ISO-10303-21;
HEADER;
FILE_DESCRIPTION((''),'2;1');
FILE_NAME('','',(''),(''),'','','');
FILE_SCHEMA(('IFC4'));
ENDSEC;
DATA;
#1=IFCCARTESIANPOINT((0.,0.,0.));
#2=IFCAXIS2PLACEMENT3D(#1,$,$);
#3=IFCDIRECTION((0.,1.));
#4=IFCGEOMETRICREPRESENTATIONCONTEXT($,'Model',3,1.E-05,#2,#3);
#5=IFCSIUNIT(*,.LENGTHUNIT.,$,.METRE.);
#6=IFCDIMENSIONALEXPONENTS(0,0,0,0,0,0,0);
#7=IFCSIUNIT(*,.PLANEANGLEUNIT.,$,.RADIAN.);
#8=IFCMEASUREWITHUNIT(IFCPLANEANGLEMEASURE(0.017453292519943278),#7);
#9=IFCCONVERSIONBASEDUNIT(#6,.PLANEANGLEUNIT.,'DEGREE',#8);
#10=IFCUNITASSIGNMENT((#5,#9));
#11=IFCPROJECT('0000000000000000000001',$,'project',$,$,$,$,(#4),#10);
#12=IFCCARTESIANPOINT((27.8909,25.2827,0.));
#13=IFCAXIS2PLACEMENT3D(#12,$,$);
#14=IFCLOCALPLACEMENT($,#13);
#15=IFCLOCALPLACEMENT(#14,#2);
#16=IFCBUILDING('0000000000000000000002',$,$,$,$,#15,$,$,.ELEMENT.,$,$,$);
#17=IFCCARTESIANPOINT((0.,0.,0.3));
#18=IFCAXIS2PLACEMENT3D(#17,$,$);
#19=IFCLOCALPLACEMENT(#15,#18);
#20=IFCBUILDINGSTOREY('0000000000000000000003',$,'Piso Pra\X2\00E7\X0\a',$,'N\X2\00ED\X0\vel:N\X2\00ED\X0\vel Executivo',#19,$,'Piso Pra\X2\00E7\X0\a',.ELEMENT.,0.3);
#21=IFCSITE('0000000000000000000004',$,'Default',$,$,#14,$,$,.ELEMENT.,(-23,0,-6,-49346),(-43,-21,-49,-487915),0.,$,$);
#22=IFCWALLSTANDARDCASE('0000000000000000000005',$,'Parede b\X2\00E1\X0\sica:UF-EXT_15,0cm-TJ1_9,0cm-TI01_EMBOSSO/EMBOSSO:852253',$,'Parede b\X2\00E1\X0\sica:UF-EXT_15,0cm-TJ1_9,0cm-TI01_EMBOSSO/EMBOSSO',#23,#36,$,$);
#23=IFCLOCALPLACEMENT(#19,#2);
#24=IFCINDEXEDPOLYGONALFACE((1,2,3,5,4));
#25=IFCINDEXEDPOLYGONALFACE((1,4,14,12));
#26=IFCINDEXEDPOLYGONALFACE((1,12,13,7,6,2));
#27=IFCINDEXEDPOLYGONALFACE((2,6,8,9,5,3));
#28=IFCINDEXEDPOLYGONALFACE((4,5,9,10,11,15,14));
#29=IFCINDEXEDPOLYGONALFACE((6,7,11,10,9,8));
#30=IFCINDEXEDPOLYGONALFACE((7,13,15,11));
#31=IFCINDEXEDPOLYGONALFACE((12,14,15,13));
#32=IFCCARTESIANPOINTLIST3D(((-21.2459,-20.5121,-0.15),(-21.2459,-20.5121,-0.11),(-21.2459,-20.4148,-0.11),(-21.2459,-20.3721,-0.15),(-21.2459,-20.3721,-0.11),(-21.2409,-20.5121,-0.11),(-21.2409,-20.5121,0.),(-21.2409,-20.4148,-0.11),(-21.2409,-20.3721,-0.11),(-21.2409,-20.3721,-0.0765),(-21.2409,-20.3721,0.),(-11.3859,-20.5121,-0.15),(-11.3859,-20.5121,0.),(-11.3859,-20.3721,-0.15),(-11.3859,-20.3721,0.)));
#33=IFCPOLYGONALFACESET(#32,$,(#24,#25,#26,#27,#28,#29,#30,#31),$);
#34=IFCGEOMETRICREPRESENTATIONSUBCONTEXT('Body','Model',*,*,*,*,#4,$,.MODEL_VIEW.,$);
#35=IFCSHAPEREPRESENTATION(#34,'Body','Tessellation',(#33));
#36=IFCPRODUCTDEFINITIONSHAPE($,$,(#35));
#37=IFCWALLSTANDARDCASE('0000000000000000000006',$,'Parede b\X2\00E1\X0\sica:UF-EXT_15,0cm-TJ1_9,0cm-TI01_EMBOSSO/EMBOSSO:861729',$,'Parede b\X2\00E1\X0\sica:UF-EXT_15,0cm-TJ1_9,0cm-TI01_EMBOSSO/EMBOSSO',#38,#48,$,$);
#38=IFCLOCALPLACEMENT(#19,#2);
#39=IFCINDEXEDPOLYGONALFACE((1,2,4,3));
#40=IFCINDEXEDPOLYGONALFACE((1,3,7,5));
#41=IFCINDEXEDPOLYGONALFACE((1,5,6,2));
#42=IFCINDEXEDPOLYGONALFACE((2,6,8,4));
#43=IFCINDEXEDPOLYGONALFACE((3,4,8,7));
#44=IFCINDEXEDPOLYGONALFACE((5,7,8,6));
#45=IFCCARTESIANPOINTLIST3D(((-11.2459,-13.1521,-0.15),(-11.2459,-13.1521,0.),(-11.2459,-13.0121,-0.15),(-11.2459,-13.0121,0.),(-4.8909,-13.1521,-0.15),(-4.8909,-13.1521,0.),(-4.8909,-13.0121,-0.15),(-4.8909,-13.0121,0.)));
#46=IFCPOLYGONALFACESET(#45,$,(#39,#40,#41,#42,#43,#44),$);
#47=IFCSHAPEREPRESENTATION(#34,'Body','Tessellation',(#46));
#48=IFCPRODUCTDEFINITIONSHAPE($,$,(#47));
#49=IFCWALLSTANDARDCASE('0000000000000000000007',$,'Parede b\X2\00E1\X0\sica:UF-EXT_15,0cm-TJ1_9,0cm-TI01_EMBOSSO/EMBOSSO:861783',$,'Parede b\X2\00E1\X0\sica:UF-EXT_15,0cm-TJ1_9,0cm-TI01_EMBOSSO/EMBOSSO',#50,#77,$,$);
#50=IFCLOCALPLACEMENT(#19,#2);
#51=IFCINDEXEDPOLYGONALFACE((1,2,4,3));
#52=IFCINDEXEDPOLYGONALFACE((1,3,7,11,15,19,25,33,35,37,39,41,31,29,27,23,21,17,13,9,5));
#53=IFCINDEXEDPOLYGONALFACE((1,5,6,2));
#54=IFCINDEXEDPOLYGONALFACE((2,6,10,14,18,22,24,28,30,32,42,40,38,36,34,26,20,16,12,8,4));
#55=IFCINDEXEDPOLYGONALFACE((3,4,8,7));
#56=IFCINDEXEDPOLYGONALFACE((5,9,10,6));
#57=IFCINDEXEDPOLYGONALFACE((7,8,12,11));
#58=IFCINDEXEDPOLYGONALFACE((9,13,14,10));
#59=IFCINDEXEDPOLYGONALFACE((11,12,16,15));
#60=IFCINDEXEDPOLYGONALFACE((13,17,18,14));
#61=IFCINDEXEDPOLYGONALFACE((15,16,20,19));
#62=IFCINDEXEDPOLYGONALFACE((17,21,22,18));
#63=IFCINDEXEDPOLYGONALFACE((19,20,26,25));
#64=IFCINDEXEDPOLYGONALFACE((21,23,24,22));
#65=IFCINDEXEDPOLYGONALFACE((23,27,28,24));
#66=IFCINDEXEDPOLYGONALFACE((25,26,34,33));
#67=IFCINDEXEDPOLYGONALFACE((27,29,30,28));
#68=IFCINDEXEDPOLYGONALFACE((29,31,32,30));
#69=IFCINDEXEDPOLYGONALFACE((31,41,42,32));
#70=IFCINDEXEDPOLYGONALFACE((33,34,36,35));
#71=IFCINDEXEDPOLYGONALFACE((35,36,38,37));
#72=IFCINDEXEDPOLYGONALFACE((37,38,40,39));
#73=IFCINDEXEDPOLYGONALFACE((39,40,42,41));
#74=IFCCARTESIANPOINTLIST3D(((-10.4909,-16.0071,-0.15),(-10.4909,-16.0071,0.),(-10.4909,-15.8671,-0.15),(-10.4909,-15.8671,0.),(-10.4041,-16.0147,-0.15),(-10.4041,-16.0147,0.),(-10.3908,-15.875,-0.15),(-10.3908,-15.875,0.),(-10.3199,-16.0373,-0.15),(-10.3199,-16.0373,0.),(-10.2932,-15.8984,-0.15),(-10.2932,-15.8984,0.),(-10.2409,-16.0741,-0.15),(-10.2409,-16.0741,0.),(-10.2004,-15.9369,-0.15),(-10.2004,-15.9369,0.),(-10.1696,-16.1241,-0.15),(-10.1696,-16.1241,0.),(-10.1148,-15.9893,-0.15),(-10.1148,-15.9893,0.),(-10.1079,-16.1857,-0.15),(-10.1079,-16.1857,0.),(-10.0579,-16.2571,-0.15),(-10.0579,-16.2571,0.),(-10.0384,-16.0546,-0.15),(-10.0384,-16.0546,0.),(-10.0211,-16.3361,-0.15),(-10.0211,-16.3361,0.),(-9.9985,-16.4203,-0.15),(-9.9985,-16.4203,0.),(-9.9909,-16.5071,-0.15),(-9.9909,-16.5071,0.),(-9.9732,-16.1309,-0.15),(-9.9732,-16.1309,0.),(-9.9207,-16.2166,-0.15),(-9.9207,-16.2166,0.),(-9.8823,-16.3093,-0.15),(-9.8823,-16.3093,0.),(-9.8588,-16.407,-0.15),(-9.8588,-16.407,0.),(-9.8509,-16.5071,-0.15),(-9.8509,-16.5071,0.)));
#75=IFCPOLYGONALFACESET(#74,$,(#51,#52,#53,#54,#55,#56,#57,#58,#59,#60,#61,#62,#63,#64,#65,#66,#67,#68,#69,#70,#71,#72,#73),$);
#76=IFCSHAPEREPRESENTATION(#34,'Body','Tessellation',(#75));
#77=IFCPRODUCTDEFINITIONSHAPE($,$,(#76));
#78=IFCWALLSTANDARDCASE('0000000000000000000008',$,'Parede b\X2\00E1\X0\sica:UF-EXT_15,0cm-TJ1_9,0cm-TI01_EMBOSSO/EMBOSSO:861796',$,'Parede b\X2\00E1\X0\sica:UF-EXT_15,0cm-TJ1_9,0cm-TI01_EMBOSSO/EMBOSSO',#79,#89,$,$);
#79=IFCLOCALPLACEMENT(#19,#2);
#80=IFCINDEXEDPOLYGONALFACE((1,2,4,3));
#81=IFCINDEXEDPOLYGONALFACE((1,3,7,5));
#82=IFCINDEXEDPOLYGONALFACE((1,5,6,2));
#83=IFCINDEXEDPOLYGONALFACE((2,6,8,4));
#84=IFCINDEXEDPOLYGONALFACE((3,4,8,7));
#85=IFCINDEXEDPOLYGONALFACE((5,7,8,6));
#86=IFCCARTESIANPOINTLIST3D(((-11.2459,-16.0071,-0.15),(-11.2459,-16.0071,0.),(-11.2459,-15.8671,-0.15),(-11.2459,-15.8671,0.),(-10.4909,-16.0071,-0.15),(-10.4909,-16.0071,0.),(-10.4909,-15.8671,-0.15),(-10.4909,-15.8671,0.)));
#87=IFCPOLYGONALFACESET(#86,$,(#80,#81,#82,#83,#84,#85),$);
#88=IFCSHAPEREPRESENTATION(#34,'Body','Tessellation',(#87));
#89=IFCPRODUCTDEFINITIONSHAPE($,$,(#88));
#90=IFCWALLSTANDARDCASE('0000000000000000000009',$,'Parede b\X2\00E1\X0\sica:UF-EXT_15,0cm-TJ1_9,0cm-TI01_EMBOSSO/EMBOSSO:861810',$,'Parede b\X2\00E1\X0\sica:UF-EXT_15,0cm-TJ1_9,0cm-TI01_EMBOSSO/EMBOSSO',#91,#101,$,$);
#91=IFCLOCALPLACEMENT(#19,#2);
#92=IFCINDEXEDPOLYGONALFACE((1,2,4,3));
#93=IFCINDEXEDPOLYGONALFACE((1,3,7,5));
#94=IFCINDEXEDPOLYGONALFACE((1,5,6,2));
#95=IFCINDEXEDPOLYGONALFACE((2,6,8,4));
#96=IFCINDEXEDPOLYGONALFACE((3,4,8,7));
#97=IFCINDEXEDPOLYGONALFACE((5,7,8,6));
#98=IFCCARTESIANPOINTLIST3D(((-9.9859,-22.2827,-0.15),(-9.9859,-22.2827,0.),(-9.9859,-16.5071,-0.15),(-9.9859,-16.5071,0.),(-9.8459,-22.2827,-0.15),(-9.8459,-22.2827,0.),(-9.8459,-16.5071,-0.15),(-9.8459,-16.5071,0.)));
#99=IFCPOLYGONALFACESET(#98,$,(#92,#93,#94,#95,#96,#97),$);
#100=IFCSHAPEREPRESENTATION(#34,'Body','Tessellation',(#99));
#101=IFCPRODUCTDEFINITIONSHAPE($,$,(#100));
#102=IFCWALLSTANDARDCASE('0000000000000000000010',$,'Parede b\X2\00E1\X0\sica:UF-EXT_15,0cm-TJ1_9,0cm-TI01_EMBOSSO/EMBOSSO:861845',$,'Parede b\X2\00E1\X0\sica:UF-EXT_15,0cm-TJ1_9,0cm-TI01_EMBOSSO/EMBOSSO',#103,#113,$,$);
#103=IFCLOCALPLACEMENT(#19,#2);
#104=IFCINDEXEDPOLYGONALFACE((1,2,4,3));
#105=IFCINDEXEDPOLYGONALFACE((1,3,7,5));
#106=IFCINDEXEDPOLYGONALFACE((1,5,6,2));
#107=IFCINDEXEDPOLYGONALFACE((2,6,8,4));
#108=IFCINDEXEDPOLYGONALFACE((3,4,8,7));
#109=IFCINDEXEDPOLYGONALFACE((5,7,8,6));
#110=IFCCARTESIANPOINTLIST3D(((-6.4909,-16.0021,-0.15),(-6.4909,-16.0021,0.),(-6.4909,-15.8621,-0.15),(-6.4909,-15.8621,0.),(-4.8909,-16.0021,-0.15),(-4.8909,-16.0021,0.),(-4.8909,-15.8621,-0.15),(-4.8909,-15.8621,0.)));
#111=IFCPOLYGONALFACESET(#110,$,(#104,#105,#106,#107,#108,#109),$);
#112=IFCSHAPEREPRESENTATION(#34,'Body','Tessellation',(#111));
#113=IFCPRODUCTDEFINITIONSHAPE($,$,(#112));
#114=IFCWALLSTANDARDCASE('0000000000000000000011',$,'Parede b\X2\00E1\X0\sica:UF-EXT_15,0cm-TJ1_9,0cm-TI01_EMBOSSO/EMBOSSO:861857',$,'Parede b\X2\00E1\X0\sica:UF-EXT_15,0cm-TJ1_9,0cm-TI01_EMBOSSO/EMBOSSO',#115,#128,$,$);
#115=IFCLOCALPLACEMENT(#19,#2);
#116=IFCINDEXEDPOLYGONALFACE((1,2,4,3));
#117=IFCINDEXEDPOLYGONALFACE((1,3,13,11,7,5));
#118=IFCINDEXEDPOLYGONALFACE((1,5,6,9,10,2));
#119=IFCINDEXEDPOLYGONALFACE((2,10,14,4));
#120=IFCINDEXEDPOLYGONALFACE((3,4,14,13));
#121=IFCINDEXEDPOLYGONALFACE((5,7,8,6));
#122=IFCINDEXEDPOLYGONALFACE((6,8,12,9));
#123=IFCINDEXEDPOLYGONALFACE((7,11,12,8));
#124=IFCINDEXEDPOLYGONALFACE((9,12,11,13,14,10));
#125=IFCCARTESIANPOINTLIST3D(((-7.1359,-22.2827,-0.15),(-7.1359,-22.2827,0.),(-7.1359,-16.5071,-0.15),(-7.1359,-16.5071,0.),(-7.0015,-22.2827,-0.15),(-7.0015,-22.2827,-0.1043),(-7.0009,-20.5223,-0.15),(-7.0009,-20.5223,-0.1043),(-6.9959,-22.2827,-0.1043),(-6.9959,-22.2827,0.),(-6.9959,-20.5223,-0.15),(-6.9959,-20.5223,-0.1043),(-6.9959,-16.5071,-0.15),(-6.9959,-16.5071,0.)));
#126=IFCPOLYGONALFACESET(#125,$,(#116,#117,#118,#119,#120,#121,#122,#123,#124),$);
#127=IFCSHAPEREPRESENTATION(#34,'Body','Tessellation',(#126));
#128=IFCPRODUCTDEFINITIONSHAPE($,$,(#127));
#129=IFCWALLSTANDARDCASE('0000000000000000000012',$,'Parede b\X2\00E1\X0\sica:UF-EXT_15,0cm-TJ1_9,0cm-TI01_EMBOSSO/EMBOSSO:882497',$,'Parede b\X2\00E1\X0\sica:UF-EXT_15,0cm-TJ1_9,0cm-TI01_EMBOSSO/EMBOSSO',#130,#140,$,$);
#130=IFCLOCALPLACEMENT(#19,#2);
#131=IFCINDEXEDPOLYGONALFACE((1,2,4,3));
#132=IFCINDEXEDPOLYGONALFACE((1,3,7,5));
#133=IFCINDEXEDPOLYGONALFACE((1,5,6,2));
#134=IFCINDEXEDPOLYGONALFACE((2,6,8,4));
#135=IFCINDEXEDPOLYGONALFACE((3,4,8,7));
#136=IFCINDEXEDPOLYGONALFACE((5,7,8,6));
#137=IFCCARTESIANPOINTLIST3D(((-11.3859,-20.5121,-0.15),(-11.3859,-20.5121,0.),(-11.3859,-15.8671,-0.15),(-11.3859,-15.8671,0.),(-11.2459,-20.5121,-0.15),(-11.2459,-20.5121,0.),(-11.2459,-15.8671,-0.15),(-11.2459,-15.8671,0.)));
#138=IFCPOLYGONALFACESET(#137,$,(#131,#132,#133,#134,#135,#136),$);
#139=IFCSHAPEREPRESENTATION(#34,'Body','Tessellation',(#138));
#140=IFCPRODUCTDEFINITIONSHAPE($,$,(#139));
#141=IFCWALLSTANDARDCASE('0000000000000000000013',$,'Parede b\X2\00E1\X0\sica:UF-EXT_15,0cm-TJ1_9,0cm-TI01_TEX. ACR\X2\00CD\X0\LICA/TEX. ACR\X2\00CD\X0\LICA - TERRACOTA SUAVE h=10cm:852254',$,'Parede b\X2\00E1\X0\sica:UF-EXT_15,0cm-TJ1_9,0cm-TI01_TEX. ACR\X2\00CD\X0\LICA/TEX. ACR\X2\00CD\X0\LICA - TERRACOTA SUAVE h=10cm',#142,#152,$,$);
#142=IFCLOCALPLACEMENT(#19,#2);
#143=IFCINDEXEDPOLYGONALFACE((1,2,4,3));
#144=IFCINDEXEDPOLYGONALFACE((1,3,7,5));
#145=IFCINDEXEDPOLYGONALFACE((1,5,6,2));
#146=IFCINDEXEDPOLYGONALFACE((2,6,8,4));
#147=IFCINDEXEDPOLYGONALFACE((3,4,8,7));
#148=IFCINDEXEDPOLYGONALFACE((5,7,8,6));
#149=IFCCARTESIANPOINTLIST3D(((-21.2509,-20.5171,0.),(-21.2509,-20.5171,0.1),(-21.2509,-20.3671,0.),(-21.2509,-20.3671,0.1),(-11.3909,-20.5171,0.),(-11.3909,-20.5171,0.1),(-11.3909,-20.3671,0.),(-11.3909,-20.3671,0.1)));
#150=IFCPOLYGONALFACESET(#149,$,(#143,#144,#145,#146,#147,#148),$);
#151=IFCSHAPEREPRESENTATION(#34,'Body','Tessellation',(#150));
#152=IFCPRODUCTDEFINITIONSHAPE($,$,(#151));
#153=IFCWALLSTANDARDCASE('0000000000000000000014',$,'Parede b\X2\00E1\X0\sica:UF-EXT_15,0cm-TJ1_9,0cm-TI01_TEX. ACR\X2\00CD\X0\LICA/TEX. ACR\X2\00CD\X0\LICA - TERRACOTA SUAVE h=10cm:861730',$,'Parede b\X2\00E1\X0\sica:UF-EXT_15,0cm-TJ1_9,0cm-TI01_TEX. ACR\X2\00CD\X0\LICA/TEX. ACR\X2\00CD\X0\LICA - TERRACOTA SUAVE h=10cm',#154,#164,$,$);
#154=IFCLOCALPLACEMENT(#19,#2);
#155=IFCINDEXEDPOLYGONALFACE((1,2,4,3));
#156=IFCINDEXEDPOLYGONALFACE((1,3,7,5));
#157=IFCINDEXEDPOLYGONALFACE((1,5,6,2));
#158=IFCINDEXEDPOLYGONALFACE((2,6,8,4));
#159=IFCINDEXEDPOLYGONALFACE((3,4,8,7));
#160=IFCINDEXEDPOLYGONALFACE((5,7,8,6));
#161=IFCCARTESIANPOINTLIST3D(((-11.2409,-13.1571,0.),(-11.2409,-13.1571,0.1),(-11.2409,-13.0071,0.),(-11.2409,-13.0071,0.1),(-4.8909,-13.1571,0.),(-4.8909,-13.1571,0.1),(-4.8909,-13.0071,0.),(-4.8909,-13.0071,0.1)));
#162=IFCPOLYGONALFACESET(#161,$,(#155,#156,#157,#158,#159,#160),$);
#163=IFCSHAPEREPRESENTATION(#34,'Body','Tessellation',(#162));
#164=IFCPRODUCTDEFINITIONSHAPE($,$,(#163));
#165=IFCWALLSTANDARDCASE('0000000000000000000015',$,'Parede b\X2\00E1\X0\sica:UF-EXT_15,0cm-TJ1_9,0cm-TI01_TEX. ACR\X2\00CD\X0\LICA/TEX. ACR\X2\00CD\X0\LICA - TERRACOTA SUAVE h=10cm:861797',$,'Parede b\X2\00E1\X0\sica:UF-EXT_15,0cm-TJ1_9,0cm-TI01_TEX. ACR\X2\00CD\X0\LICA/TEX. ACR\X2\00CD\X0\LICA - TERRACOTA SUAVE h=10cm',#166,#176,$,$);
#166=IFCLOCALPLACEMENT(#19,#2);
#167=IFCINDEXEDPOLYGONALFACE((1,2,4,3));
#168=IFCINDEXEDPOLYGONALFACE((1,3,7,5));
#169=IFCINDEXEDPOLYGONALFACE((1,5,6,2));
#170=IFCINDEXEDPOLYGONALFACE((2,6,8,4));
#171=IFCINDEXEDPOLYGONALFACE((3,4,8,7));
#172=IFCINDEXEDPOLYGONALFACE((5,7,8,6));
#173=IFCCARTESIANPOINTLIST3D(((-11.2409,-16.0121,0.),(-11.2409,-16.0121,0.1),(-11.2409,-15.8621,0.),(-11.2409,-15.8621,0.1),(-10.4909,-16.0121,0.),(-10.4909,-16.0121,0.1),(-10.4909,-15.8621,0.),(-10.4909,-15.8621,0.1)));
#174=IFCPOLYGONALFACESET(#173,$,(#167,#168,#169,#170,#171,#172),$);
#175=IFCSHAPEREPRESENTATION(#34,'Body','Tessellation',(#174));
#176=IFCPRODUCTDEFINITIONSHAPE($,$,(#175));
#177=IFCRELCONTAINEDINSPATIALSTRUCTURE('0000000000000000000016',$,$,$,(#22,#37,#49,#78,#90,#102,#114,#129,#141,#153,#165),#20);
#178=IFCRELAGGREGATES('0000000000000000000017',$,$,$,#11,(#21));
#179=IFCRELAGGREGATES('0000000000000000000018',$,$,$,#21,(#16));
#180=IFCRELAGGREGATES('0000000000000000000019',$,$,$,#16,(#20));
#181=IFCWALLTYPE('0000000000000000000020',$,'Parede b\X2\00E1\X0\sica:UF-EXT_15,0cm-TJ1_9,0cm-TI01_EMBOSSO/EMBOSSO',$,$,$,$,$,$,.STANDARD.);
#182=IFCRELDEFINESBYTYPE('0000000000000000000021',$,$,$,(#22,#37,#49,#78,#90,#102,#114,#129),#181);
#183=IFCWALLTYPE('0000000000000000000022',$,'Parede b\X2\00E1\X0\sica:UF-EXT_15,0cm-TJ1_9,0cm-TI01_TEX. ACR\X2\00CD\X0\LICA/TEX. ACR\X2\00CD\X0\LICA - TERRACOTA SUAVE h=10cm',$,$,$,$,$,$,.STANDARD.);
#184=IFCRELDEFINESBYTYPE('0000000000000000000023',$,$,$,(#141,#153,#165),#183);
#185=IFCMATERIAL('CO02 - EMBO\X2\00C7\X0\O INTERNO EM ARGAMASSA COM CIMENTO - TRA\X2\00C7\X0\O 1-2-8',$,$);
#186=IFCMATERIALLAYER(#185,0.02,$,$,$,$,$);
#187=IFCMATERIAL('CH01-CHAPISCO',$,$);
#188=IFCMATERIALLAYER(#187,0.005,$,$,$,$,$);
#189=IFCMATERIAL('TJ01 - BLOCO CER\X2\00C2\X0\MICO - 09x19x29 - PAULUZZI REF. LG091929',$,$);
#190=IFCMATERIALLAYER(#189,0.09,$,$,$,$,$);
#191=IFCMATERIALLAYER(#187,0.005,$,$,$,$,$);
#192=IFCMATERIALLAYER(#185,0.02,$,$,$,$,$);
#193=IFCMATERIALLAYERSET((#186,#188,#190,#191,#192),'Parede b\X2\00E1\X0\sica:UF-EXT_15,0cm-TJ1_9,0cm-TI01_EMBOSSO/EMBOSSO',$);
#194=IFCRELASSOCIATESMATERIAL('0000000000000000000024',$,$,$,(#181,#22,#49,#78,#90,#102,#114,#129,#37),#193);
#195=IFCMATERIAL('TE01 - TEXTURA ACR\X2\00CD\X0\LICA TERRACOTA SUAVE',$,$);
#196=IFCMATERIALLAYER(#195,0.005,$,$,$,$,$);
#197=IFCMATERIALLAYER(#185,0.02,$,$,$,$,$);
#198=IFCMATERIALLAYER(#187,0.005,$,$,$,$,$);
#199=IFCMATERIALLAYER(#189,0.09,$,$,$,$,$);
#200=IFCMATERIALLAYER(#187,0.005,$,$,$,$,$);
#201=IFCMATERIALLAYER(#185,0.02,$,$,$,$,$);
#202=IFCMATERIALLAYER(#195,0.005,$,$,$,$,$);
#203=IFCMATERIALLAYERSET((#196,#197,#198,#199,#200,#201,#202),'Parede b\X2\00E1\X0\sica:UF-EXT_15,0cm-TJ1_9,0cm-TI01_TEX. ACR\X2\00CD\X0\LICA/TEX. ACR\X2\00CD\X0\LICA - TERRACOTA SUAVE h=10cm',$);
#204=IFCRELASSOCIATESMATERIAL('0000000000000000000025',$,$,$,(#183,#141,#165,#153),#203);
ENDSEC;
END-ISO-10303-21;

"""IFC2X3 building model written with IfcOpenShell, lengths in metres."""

from ifc_helpers import new_model, entity, si_unit, converted_unit, direction, frame, frame_2d, origin, place, context, subcontext, project, spatial, polyline, circle_curve, parameter, trimmed, segment, composite_curve, rectangle, outline, extrude, clip, bounded_halfspace, material, layer, layer_set, layer_usage, type_object, element, save


model = new_model("IFC2X3")

# Units and contexts
model_context = context("Model", 3, precision=1e-05, world=origin(), true_north=direction((0.0, 1.0)))
body_context = subcontext(model_context, "Body", "Model", "MODEL_VIEW")
ifc_project = project(units=[si_unit("LENGTHUNIT", "METRE"), converted_unit("PLANEANGLEUNIT", "DEGREE", entity("IfcPlaneAngleMeasure", 0.017453292519943278), si_unit("PLANEANGLEUNIT", "RADIAN"), dimensions=[0, 0, 0, 0, 0, 0, 0])], contexts=[model_context])

# Site, building, storey
site_placement = place(None, frame((27.8909, 25.2827, 0.0)))
site = spatial("IfcSite", under=ifc_project, at=site_placement, Name="Default", CompositionType="ELEMENT", RefLatitude=(-23, 0, -6, -49346), RefLongitude=(-43, -21, -49, -487915), RefElevation=0.0)
building_placement = place(site_placement, origin())
building = spatial("IfcBuilding", under=site, at=building_placement, CompositionType="ELEMENT")
storey_placement = place(building_placement, frame((0.0, 0.0, 0.3)))
storey = spatial("IfcBuildingStorey", under=building, at=storey_placement, Name="Piso Praça", ObjectType="Nível:Nível Executivo", LongName="Piso Praça", CompositionType="ELEMENT", Elevation=0.3)

# Walls
ifc_material_1 = material(Name="CO02 - EMBOÇO INTERNO EM ARGAMASSA COM CIMENTO - TRAÇO 1-2-8")
ifc_layer_1 = layer(ifc_material_1, 0.02)
ifc_material_2 = material(Name="CH01-CHAPISCO")
ifc_layer_2 = layer(ifc_material_2, 0.005)
ifc_material_3 = material(Name="TJ01 - BLOCO CERÂMICO - 09x19x29 - PAULUZZI REF. LG091929")
ifc_layer_3 = layer(ifc_material_3, 0.09)
ifc_layer_4 = layer(ifc_material_2, 0.005)
ifc_layer_5 = layer(ifc_material_1, 0.02)
ifc_layer_set_1 = layer_set([ifc_layer_1, ifc_layer_2, ifc_layer_3, ifc_layer_4, ifc_layer_5], Name="Parede básica:UF-EXT_15,0cm-TJ1_9,0cm-TI01_EMBOSSO/EMBOSSO")
ifc_layer_usage_1 = layer_usage(ifc_layer_set_1, "AXIS2", "NEGATIVE", 0.07)
wall_type_1 = type_object("IfcWallType", Name="Parede básica:UF-EXT_15,0cm-TJ1_9,0cm-TI01_EMBOSSO/EMBOSSO", PredefinedType="STANDARD", material=ifc_layer_set_1)
wall_1_placement = place(storey_placement, frame((-11.3859, -20.4421, -0.15), z_axis=(0.0, 0.0, 1.0), x_axis=(-1.0, 0.0, 0.0)))
element("IfcWallStandardCase", 1, at=wall_1_placement, inside=storey, type_object=wall_type_1, material=ifc_layer_usage_1, Name="Parede básica:UF-EXT_15,0cm-TJ1_9,0cm-TI01_EMBOSSO/EMBOSSO:852253", ObjectType="Parede básica:UF-EXT_15,0cm-TJ1_9,0cm-TI01_EMBOSSO/EMBOSSO", context=body_context, shape_type="Clipping", body=[
    clip(clip(extrude(rectangle(XDim=9.86, YDim=0.14, at=frame_2d((4.93, 0.0), x_axis=(-1.0, 0.0))), origin(), (0.0, 0.0, 1.0), 0.15), bounded_halfspace(frame((9.855, 0.07, 0.04), z_axis=(0.0, 0.0, -1.0), x_axis=(-1.0, 0.0, 0.0)), True, frame((9.855, 0.07, 0.04), z_axis=(0.0, 0.0, -1.0), x_axis=(-1.0, 0.0, 0.0)), polyline([(0.0, 0.0), (-0.005, 0.0), (-0.005, -0.14), (0.0, -0.14), (0.0, 0.0)]))), bounded_halfspace(frame((9.855, -0.07, 0.04), z_axis=(-1.0, 0.0, 0.0), x_axis=(0.0, 0.0, 1.0)), True, frame((9.855, -0.07, 0.04), z_axis=(-1.0, 0.0, 0.0), x_axis=(0.0, 0.0, 1.0)), polyline([(0.0, 0.0), (0.0335, 0.0), (0.0335, 0.0427), (0.0, 0.0427), (0.0, 0.0)]))),
])
ifc_layer_usage_2 = layer_usage(ifc_layer_set_1, "AXIS2", "POSITIVE", -0.07)
wall_2_placement = place(storey_placement, frame((-11.2459, -13.0821, -0.15)))
element("IfcWallStandardCase", 2, at=wall_2_placement, inside=storey, type_object=wall_type_1, material=ifc_layer_usage_2, Name="Parede básica:UF-EXT_15,0cm-TJ1_9,0cm-TI01_EMBOSSO/EMBOSSO:861729", ObjectType="Parede básica:UF-EXT_15,0cm-TJ1_9,0cm-TI01_EMBOSSO/EMBOSSO", context=body_context, shape_type="SweptSolid", body=[
    extrude(rectangle(XDim=6.355, YDim=0.14, at=frame_2d((3.1775, 0.0), x_axis=(-1.0, 0.0))), origin(), (0.0, 0.0, 1.0), 0.15),
])
wall_3_placement = place(storey_placement, frame((-9.9209, -16.5071, -0.15)))
element("IfcWallStandardCase", 3, at=wall_3_placement, inside=storey, type_object=wall_type_1, material=ifc_layer_usage_1, Name="Parede básica:UF-EXT_15,0cm-TJ1_9,0cm-TI01_EMBOSSO/EMBOSSO:861783", ObjectType="Parede básica:UF-EXT_15,0cm-TJ1_9,0cm-TI01_EMBOSSO/EMBOSSO", context=body_context, shape_type="SweptSolid", body=[
    extrude(outline(composite_curve([segment(trimmed(circle_curve(frame_2d((-0.57, 0.0), x_axis=(1.0, 0.0)), 0.5), [parameter(0.0)], [parameter(90.0)], True, "PARAMETER"), False, "CONTINUOUS"), segment(polyline([(-0.07, 0.0), (0.07, 0.0)]), True, "CONTINUOUS"), segment(trimmed(circle_curve(frame_2d((-0.57, 0.0), x_axis=(1.0, 0.0)), 0.64), [parameter(0.0)], [parameter(90.0)], True, "PARAMETER"), True, "CONTINUOUS"), segment(polyline([(-0.57, 0.64), (-0.57, 0.5)]), True, "CONTINUOUS")], self_intersect=False)), origin(), (0.0, 0.0, 1.0), 0.15),
])
wall_4_placement = place(storey_placement, frame((-10.4909, -15.9371, -0.15), z_axis=(0.0, 0.0, 1.0), x_axis=(-1.0, 0.0, 0.0)))
element("IfcWallStandardCase", 4, at=wall_4_placement, inside=storey, type_object=wall_type_1, material=ifc_layer_usage_1, Name="Parede básica:UF-EXT_15,0cm-TJ1_9,0cm-TI01_EMBOSSO/EMBOSSO:861796", ObjectType="Parede básica:UF-EXT_15,0cm-TJ1_9,0cm-TI01_EMBOSSO/EMBOSSO", context=body_context, shape_type="SweptSolid", body=[
    extrude(rectangle(XDim=0.755, YDim=0.14, at=frame_2d((0.3775, 0.0), x_axis=(-1.0, 0.0))), origin(), (0.0, 0.0, 1.0), 0.15),
])
wall_5_placement = place(storey_placement, frame((-9.9159, -22.2827, -0.15), z_axis=(0.0, 0.0, 1.0), x_axis=(0.0, 1.0, 0.0)))
element("IfcWallStandardCase", 5, at=wall_5_placement, inside=storey, type_object=wall_type_1, material=ifc_layer_usage_1, Name="Parede básica:UF-EXT_15,0cm-TJ1_9,0cm-TI01_EMBOSSO/EMBOSSO:861810", ObjectType="Parede básica:UF-EXT_15,0cm-TJ1_9,0cm-TI01_EMBOSSO/EMBOSSO", context=body_context, shape_type="SweptSolid", body=[
    extrude(rectangle(XDim=5.7756, YDim=0.14, at=frame_2d((2.8878, 0.0), x_axis=(-1.0, 0.0))), origin(), (0.0, 0.0, 1.0), 0.15),
])
wall_6_placement = place(storey_placement, frame((-6.4909, -15.9321, -0.15)))
element("IfcWallStandardCase", 6, at=wall_6_placement, inside=storey, type_object=wall_type_1, material=ifc_layer_usage_1, Name="Parede básica:UF-EXT_15,0cm-TJ1_9,0cm-TI01_EMBOSSO/EMBOSSO:861845", ObjectType="Parede básica:UF-EXT_15,0cm-TJ1_9,0cm-TI01_EMBOSSO/EMBOSSO", context=body_context, shape_type="SweptSolid", body=[
    extrude(rectangle(XDim=1.6, YDim=0.14, at=frame_2d((0.8, 0.0), x_axis=(-1.0, 0.0))), origin(), (0.0, 0.0, 1.0), 0.15),
])
wall_7_placement = place(storey_placement, frame((-7.0659, -22.2827, -0.15), z_axis=(0.0, 0.0, 1.0), x_axis=(0.0, 1.0, 0.0)))
element("IfcWallStandardCase", 7, at=wall_7_placement, inside=storey, type_object=wall_type_1, material=ifc_layer_usage_1, Name="Parede básica:UF-EXT_15,0cm-TJ1_9,0cm-TI01_EMBOSSO/EMBOSSO:861857", ObjectType="Parede básica:UF-EXT_15,0cm-TJ1_9,0cm-TI01_EMBOSSO/EMBOSSO", context=body_context, shape_type="Clipping", body=[
    clip(extrude(rectangle(XDim=5.7756, YDim=0.14, at=frame_2d((2.8878, 0.0), x_axis=(-1.0, 0.0))), origin(), (0.0, 0.0, 1.0), 0.15), bounded_halfspace(frame((0.0, -0.0645, 0.0), z_axis=(0.00031, 1.0, 0.0), x_axis=(0.0, 0.0, 1.0)), True, frame((0.0, -0.0645, 0.0), z_axis=(0.00031, 1.0, 0.0), x_axis=(0.0, 0.0, 1.0)), polyline([(0.0, 0.0), (0.0457, 0.0), (0.0457, 1.7604), (0.0, 1.7604), (0.0, 0.0)]))),
])
wall_8_placement = place(storey_placement, frame((-11.3159, -15.8671, -0.15), z_axis=(0.0, 0.0, 1.0), x_axis=(0.0, -1.0, 0.0)))
element("IfcWallStandardCase", 8, at=wall_8_placement, inside=storey, type_object=wall_type_1, material=ifc_layer_usage_1, Name="Parede básica:UF-EXT_15,0cm-TJ1_9,0cm-TI01_EMBOSSO/EMBOSSO:882497", ObjectType="Parede básica:UF-EXT_15,0cm-TJ1_9,0cm-TI01_EMBOSSO/EMBOSSO", context=body_context, shape_type="SweptSolid", body=[
    extrude(rectangle(XDim=4.645, YDim=0.14, at=frame_2d((2.3225, 0.0), x_axis=(-1.0, 0.0))), origin(), (0.0, 0.0, 1.0), 0.15),
])
ifc_material_4 = material(Name="TE01 - TEXTURA ACRÍLICA TERRACOTA SUAVE")
ifc_layer_6 = layer(ifc_material_4, 0.005)
ifc_layer_7 = layer(ifc_material_1, 0.02)
ifc_layer_8 = layer(ifc_material_2, 0.005)
ifc_layer_9 = layer(ifc_material_3, 0.09)
ifc_layer_10 = layer(ifc_material_2, 0.005)
ifc_layer_11 = layer(ifc_material_1, 0.02)
ifc_layer_12 = layer(ifc_material_4, 0.005)
ifc_layer_set_2 = layer_set([ifc_layer_6, ifc_layer_7, ifc_layer_8, ifc_layer_9, ifc_layer_10, ifc_layer_11, ifc_layer_12], Name="Parede básica:UF-EXT_15,0cm-TJ1_9,0cm-TI01_TEX. ACRÍLICA/TEX. ACRÍLICA - TERRACOTA SUAVE h=10cm")
ifc_layer_usage_3 = layer_usage(ifc_layer_set_2, "AXIS2", "NEGATIVE", 0.075)
wall_type_2 = type_object("IfcWallType", Name="Parede básica:UF-EXT_15,0cm-TJ1_9,0cm-TI01_TEX. ACRÍLICA/TEX. ACRÍLICA - TERRACOTA SUAVE h=10cm", PredefinedType="STANDARD", material=ifc_layer_set_2)
wall_9_placement = place(storey_placement, frame((-11.3909, -20.4421, 0.0), z_axis=(0.0, 0.0, 1.0), x_axis=(-1.0, 0.0, 0.0)))
element("IfcWallStandardCase", 9, at=wall_9_placement, inside=storey, type_object=wall_type_2, material=ifc_layer_usage_3, Name="Parede básica:UF-EXT_15,0cm-TJ1_9,0cm-TI01_TEX. ACRÍLICA/TEX. ACRÍLICA - TERRACOTA SUAVE h=10cm:852254", ObjectType="Parede básica:UF-EXT_15,0cm-TJ1_9,0cm-TI01_TEX. ACRÍLICA/TEX. ACRÍLICA - TERRACOTA SUAVE h=10cm", context=body_context, shape_type="SweptSolid", body=[
    extrude(rectangle(XDim=9.86, YDim=0.15, at=frame_2d((4.93, 0.0), x_axis=(-1.0, 0.0))), origin(), (0.0, 0.0, 1.0), 0.1),
])
ifc_layer_usage_4 = layer_usage(ifc_layer_set_2, "AXIS2", "POSITIVE", -0.075)
wall_10_placement = place(storey_placement, frame((-11.2409, -13.0821, 0.0)))
element("IfcWallStandardCase", 10, at=wall_10_placement, inside=storey, type_object=wall_type_2, material=ifc_layer_usage_4, Name="Parede básica:UF-EXT_15,0cm-TJ1_9,0cm-TI01_TEX. ACRÍLICA/TEX. ACRÍLICA - TERRACOTA SUAVE h=10cm:861730", ObjectType="Parede básica:UF-EXT_15,0cm-TJ1_9,0cm-TI01_TEX. ACRÍLICA/TEX. ACRÍLICA - TERRACOTA SUAVE h=10cm", context=body_context, shape_type="SweptSolid", body=[
    extrude(rectangle(XDim=6.35, YDim=0.15, at=frame_2d((3.175, 0.0), x_axis=(-1.0, 0.0))), origin(), (0.0, 0.0, 1.0), 0.1),
])
wall_11_placement = place(storey_placement, frame((-10.4909, -15.9371, 0.0), z_axis=(0.0, 0.0, 1.0), x_axis=(-1.0, 0.0, 0.0)))
element("IfcWallStandardCase", 11, at=wall_11_placement, inside=storey, type_object=wall_type_2, material=ifc_layer_usage_3, Name="Parede básica:UF-EXT_15,0cm-TJ1_9,0cm-TI01_TEX. ACRÍLICA/TEX. ACRÍLICA - TERRACOTA SUAVE h=10cm:861797", ObjectType="Parede básica:UF-EXT_15,0cm-TJ1_9,0cm-TI01_TEX. ACRÍLICA/TEX. ACRÍLICA - TERRACOTA SUAVE h=10cm", context=body_context, shape_type="SweptSolid", body=[
    extrude(rectangle(XDim=0.75, YDim=0.15, at=frame_2d((0.375, 0.0), x_axis=(-1.0, 0.0))), origin(), (0.0, 0.0, 1.0), 0.1),
])

save(model, "model.ifc")
